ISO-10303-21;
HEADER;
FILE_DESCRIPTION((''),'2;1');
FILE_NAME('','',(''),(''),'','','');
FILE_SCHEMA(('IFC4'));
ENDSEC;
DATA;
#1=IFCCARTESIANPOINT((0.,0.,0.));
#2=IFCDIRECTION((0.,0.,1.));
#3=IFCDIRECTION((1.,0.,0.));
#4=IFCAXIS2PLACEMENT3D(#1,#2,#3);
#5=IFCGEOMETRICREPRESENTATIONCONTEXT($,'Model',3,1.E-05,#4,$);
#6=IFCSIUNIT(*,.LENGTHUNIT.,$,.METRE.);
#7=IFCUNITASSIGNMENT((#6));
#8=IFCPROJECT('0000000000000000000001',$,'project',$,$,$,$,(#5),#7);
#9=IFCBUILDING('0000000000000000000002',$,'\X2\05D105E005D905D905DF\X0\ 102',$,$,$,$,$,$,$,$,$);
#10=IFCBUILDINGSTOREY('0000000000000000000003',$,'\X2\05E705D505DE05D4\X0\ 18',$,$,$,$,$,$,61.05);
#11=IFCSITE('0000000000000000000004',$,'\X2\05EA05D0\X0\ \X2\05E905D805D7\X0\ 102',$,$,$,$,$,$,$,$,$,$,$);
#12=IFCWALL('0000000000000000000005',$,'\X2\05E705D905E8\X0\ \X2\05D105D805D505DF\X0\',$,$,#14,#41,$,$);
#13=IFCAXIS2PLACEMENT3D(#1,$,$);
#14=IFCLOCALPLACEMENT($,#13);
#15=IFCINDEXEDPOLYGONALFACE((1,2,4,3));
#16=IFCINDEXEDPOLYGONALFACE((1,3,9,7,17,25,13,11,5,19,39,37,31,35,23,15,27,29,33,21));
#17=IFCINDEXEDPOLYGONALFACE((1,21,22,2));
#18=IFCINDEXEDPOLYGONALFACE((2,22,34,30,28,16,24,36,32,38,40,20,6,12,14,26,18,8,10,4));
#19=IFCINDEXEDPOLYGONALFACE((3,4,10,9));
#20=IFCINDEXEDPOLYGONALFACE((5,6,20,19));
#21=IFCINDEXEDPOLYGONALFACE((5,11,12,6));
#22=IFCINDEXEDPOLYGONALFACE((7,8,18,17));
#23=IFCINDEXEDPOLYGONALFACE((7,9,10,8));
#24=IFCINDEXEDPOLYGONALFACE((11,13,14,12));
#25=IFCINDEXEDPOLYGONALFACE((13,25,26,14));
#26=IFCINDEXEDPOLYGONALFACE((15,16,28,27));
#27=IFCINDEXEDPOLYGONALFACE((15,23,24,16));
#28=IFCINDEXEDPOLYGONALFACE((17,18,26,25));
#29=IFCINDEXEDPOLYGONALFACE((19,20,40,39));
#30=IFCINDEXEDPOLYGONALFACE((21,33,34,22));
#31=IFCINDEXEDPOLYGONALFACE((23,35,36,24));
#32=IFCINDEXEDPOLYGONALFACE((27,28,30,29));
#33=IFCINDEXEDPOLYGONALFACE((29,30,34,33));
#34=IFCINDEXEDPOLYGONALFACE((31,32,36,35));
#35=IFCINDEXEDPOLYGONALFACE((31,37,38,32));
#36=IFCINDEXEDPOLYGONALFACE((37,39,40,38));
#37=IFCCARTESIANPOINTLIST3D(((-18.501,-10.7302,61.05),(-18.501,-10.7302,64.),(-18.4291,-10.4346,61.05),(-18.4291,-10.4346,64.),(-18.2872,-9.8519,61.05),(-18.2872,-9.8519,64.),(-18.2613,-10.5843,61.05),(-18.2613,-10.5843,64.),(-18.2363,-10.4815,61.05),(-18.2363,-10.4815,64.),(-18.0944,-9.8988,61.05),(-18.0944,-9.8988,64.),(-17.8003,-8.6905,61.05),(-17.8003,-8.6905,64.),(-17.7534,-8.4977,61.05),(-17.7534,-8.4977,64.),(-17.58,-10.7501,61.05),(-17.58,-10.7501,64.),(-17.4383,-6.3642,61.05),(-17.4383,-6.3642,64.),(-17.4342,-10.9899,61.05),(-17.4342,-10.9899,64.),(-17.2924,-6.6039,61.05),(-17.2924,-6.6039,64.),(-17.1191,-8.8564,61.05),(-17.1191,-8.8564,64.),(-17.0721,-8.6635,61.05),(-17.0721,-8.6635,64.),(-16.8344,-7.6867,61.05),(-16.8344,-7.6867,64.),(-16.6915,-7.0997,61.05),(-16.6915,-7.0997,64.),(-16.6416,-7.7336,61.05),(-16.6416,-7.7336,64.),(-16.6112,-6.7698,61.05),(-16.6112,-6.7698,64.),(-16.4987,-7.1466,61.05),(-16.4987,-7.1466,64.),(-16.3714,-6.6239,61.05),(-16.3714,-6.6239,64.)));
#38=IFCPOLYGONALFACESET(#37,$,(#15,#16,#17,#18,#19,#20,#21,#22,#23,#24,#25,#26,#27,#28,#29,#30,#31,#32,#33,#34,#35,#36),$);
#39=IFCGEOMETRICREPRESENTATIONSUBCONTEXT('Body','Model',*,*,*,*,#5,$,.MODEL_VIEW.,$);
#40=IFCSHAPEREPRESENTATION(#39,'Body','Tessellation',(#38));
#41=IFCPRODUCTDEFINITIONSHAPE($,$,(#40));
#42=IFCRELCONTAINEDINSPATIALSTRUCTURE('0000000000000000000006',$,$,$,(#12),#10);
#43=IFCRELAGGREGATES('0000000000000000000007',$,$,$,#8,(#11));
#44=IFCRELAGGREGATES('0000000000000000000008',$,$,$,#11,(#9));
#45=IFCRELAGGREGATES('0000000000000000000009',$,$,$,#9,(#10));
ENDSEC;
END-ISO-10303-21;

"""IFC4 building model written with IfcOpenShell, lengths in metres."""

from ifc_helpers import new_model, si_unit, frame, origin_with_axes, context, subcontext, project, spatial, polyline, outline, extrude, element, save


model = new_model("IFC4")

# Units and contexts
model_context = context("Model", 3, precision=1e-05, world=origin_with_axes())
body_context = subcontext(model_context, "Body", "Model", "MODEL_VIEW")
ifc_project = project(units=[si_unit("LENGTHUNIT", "METRE")], contexts=[model_context])

# Site, building, storey
site = spatial("IfcSite", under=ifc_project, Name="תא שטח 102")
building = spatial("IfcBuilding", under=site, Name="בניין 102")
storey = spatial("IfcBuildingStorey", under=building, Name="קומה 18", Elevation=61.05)

# Wall
element("IfcWall", 1, inside=storey, Name="קיר בטון", context=body_context, shape_type="SweptSolid", body=[
    extrude(outline(polyline([(-18.4291, -10.4346), (-18.501, -10.7302), (-17.4342, -10.9899), (-16.6416, -7.7336), (-16.8344, -7.6867), (-17.0721, -8.6635), (-17.7534, -8.4977), (-17.2924, -6.6039), (-16.6112, -6.7698), (-16.6915, -7.0997), (-16.4987, -7.1466), (-16.3714, -6.6239), (-17.4383, -6.3642), (-18.2872, -9.8519), (-18.0944, -9.8988), (-17.8003, -8.6905), (-17.1191, -8.8564), (-17.58, -10.7501), (-18.2613, -10.5843), (-18.2363, -10.4815), (-18.4291, -10.4346)])), frame((0.0, 0.0, 61.05)), (0.0, 0.0, 1.0), 2.95),
])

save(model, "model.ifc")
